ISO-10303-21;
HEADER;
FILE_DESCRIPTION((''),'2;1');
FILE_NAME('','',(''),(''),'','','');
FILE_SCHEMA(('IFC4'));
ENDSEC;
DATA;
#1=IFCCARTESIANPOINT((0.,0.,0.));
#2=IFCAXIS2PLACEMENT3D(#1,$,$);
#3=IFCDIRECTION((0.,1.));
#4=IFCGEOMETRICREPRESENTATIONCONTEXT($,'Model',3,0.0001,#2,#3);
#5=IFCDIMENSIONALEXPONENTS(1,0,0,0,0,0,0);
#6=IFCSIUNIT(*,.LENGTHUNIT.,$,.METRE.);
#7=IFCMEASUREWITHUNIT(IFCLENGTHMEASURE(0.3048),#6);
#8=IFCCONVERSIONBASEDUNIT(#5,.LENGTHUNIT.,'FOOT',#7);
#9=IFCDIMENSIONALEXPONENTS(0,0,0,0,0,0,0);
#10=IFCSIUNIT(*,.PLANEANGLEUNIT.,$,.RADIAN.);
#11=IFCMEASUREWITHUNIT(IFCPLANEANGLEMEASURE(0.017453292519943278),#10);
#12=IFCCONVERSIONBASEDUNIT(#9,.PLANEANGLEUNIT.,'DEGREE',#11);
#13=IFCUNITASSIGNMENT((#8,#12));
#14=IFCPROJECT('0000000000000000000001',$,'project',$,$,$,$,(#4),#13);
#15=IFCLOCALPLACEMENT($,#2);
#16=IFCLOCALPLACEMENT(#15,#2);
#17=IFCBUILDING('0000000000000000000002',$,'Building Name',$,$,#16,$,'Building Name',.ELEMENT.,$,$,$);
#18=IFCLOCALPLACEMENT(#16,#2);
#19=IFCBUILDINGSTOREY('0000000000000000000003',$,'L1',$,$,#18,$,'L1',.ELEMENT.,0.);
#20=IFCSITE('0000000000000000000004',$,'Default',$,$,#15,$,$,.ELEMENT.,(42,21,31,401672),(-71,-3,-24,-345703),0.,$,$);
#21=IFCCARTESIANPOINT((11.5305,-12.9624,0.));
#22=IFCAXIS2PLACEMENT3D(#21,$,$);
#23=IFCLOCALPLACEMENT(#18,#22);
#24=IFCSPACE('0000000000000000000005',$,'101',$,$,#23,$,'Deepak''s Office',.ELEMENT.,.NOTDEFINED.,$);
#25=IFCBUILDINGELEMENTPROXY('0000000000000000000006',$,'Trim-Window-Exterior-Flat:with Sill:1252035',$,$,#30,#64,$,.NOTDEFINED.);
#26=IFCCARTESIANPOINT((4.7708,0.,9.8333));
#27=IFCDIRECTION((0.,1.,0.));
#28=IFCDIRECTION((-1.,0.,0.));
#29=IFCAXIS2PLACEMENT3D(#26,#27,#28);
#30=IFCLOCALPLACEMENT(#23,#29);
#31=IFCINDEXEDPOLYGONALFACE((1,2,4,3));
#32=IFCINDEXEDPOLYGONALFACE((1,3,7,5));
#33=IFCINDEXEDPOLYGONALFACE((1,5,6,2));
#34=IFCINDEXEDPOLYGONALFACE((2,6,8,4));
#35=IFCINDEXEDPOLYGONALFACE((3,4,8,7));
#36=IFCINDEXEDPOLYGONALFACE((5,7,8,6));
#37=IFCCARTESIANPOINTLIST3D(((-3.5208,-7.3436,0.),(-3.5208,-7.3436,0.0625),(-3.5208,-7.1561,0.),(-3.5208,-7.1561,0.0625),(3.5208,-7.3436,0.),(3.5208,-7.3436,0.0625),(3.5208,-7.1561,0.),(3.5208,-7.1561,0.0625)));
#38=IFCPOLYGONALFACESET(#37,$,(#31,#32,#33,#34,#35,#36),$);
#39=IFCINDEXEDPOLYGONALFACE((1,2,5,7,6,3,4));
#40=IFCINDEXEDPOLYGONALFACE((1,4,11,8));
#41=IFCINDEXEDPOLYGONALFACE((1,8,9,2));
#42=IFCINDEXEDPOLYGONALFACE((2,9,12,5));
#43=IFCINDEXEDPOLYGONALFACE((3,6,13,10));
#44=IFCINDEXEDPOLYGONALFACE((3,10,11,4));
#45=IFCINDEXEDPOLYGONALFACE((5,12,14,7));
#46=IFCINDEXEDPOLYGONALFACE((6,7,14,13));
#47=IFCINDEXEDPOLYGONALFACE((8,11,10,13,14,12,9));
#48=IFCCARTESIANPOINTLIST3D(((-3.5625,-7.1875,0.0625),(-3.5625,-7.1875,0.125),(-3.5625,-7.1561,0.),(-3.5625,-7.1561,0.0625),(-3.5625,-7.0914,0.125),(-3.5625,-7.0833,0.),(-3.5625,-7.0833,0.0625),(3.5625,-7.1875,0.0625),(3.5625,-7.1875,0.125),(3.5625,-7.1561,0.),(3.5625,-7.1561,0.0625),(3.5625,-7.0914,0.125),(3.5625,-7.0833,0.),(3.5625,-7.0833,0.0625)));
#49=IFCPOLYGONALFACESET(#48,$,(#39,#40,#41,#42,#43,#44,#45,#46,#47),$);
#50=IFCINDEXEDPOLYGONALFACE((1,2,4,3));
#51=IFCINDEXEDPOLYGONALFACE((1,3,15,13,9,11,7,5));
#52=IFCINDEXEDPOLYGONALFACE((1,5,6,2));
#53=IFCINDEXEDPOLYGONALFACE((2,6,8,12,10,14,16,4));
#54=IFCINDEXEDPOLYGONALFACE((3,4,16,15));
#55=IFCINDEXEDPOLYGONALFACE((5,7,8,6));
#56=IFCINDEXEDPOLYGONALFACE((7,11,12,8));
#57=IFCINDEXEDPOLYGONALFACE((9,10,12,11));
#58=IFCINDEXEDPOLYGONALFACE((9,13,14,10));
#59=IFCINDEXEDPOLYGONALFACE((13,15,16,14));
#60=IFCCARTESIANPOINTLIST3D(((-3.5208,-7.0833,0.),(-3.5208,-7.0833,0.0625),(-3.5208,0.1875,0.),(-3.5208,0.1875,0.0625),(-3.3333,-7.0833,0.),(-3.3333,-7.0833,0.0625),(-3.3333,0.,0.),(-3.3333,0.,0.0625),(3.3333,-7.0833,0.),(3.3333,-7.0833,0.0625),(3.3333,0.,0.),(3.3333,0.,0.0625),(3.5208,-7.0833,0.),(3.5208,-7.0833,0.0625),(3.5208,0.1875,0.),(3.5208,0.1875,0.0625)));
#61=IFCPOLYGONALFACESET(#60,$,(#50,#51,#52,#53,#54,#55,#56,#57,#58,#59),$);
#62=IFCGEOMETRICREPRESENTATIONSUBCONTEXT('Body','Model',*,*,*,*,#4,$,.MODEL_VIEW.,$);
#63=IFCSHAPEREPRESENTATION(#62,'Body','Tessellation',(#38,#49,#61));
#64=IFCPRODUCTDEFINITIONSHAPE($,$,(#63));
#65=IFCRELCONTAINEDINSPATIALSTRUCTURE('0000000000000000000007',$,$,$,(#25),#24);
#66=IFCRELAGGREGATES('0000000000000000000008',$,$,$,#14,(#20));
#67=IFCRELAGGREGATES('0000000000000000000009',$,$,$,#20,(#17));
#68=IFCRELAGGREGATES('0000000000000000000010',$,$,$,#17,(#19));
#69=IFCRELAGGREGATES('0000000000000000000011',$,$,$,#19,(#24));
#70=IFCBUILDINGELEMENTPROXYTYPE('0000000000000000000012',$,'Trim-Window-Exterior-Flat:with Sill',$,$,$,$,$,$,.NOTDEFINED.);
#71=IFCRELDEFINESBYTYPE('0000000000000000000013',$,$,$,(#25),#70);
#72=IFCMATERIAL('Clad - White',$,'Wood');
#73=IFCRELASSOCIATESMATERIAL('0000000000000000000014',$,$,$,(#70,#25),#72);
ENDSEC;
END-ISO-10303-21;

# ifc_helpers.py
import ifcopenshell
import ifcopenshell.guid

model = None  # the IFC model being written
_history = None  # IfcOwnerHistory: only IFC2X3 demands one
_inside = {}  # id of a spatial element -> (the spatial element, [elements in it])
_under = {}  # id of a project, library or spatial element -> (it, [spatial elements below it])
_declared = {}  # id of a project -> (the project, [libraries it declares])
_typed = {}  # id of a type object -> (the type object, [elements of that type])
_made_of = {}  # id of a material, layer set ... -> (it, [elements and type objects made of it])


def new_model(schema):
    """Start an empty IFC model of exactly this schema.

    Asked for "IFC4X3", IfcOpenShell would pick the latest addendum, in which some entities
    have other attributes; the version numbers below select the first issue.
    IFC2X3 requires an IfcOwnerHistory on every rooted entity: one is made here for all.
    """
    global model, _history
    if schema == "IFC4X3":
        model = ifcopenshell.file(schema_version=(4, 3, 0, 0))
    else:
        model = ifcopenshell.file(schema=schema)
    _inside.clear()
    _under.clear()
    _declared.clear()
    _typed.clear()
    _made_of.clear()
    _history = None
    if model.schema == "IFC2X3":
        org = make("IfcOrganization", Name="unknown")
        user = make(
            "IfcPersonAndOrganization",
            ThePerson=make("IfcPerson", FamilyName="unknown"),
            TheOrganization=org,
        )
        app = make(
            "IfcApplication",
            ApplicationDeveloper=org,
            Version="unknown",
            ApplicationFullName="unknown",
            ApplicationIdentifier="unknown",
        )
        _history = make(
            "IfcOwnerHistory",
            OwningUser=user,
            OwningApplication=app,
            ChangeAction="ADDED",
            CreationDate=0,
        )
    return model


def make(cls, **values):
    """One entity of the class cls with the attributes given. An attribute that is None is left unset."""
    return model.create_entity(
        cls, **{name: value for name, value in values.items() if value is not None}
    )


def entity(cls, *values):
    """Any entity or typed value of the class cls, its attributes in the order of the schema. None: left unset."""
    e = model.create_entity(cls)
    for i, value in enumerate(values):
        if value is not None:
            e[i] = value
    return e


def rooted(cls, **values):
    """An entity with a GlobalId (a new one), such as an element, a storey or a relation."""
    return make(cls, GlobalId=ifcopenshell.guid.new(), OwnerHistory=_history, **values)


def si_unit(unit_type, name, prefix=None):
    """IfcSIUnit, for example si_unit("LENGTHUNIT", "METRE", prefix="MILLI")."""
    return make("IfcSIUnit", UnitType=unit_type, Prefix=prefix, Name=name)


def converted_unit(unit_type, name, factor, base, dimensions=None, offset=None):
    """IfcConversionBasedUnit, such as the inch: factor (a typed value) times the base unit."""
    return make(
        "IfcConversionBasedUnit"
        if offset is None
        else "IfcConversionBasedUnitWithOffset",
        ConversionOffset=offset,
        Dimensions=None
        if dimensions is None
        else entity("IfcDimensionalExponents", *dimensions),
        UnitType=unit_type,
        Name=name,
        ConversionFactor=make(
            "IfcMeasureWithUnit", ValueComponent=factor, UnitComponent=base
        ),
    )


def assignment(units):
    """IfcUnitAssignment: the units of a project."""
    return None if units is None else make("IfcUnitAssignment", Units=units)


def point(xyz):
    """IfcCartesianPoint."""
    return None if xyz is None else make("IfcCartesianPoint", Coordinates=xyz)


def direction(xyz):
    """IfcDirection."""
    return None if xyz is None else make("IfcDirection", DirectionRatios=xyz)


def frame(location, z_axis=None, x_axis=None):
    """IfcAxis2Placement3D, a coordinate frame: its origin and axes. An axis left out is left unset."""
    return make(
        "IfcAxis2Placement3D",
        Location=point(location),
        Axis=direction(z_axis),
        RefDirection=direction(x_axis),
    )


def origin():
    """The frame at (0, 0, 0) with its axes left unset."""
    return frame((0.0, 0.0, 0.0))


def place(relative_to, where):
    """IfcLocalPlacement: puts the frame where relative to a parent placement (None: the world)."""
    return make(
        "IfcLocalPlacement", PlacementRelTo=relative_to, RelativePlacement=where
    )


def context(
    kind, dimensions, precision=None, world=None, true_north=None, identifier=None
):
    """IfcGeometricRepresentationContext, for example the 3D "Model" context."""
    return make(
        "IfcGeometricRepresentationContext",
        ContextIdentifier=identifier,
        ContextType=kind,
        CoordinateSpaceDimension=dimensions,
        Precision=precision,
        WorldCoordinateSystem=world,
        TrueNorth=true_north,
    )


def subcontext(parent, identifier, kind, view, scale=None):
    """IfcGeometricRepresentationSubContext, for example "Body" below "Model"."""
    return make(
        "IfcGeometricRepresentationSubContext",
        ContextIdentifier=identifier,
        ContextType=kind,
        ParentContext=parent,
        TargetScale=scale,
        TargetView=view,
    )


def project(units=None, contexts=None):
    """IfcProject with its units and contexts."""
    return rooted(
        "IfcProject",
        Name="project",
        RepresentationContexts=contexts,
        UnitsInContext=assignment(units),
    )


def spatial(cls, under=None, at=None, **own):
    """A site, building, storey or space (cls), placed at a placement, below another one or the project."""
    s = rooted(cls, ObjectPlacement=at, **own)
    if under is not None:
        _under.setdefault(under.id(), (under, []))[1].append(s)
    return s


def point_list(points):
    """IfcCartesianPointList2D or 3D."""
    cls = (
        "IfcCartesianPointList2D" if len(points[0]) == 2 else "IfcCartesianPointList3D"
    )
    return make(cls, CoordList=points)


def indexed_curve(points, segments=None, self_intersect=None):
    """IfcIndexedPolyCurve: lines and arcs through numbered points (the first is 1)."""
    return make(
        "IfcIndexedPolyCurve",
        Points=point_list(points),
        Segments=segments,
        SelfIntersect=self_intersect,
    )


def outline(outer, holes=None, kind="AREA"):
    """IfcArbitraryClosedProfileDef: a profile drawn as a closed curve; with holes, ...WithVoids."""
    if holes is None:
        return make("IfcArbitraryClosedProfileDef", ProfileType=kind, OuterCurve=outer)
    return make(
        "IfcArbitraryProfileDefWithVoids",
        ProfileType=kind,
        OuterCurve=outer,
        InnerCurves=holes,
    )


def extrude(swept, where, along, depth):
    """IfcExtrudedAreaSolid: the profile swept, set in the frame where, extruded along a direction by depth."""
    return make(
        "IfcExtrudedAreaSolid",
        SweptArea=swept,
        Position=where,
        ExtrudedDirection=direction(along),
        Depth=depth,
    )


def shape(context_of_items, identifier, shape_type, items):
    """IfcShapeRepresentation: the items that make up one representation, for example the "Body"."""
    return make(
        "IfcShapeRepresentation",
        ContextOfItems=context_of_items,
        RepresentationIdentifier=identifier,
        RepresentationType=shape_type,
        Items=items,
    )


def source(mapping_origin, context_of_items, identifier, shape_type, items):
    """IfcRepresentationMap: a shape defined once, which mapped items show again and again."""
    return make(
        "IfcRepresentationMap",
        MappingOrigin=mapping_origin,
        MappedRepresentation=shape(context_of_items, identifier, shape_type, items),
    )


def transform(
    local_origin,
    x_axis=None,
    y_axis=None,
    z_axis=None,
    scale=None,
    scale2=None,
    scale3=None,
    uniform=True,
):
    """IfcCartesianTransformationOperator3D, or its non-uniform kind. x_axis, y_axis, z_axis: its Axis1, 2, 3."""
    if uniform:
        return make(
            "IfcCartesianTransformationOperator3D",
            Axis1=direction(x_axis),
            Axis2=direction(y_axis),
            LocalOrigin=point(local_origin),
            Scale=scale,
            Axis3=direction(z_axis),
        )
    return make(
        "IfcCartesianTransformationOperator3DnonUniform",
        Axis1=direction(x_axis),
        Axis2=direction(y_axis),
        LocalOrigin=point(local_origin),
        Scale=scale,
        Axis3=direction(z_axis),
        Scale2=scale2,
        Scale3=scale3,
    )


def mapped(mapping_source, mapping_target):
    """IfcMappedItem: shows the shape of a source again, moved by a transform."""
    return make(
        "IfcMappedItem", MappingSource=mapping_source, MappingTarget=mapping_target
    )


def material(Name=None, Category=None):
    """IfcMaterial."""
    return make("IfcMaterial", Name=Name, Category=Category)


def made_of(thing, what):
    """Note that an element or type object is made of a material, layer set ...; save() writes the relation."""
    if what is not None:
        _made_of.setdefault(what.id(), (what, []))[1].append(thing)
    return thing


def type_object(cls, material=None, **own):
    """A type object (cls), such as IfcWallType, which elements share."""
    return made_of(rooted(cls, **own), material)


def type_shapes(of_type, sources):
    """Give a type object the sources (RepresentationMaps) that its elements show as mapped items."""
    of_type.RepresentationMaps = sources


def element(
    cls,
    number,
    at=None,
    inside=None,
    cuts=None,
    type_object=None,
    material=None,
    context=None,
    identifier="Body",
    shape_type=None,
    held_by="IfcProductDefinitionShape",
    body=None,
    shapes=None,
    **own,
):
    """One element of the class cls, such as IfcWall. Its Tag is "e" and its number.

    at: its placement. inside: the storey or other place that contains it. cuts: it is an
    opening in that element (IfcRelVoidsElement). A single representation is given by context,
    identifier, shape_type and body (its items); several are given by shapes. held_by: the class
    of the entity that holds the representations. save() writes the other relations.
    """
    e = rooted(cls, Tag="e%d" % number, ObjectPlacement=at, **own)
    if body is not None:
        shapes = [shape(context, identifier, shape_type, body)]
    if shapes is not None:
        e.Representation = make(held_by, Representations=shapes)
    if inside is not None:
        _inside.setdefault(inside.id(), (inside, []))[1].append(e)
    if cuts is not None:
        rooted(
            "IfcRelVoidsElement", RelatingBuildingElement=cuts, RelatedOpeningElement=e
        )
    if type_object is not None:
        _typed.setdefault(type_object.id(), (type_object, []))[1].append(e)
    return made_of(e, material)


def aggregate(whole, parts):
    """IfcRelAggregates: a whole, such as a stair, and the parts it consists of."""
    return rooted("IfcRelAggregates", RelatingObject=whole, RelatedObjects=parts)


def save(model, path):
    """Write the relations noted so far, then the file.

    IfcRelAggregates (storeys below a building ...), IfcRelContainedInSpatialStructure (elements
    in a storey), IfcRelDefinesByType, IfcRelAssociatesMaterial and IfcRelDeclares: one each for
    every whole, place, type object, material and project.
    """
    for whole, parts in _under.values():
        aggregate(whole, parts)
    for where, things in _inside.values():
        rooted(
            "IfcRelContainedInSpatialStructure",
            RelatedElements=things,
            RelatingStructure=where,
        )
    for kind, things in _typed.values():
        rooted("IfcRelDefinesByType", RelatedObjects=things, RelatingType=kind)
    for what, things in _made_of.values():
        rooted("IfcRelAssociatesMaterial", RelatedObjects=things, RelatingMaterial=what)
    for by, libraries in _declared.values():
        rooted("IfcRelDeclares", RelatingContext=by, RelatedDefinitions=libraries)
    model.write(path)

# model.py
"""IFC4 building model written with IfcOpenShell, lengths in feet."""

from ifc_helpers import new_model, entity, si_unit, converted_unit, direction, frame, origin, place, context, subcontext, project, spatial, indexed_curve, outline, extrude, source, transform, mapped, material, type_object, type_shapes, element, save


model = new_model("IFC4")

# Units and contexts
model_context = context("Model", 3, precision=0.0001, world=origin(), true_north=direction((0.0, 1.0)))
body_context = subcontext(model_context, "Body", "Model", "MODEL_VIEW")
ifc_project = project(units=[converted_unit("LENGTHUNIT", "FOOT", entity("IfcLengthMeasure", 0.3048), si_unit("LENGTHUNIT", "METRE"), dimensions=[1, 0, 0, 0, 0, 0, 0]), converted_unit("PLANEANGLEUNIT", "DEGREE", entity("IfcPlaneAngleMeasure", 0.017453292519943278), si_unit("PLANEANGLEUNIT", "RADIAN"), dimensions=[0, 0, 0, 0, 0, 0, 0])], contexts=[model_context])

# Site, building, storey
site_placement = place(None, origin())
site = spatial("IfcSite", under=ifc_project, at=site_placement, Name="Default", CompositionType="ELEMENT", RefLatitude=(42, 21, 31, 401672), RefLongitude=(-71, -3, -24, -345703), RefElevation=0.0)
building_placement = place(site_placement, origin())
building = spatial("IfcBuilding", under=site, at=building_placement, Name="Building Name", LongName="Building Name", CompositionType="ELEMENT")
storey_placement = place(building_placement, origin())
storey = spatial("IfcBuildingStorey", under=building, at=storey_placement, Name="L1", LongName="L1", CompositionType="ELEMENT", Elevation=0.0)

# Shared definitions
ifc_material_1 = material(Name="Clad - White", Category="Wood")

# Shared definitions
space_1_placement = place(storey_placement, frame((11.5305, -12.9624, 0.0)))
space_1 = spatial("IfcSpace", under=storey, at=space_1_placement, Name="101", LongName="Deepak's Office", CompositionType="ELEMENT", PredefinedType="NOTDEFINED")

# Building element proxy
building_element_proxy_type_1 = type_object("IfcBuildingElementProxyType", Name="Trim-Window-Exterior-Flat:with Sill", PredefinedType="NOTDEFINED", material=ifc_material_1)
shared_shape_1 = source(origin(), body_context, "Body", "SweptSolid", [
    extrude(outline(indexed_curve([(-3.5208, -0.0938), (3.5208, -0.0938), (3.5208, 0.0938), (-3.5208, 0.0938), (-3.5208, -0.0938)], self_intersect=False)), frame((0.0, -7.2499, 0.0), z_axis=(0.0, 0.0, 1.0), x_axis=(-1.0, 0.0, 0.0)), (0.0, 0.0, 1.0), 0.0625),
    extrude(outline(indexed_curve([(-0.0625, -0.0525), (0.0, -0.0525), (0.0, -0.0211), (0.0625, -0.0211), (0.0625, 0.0517), (0.0, 0.0517), (-0.0625, 0.0436), (-0.0625, -0.0525)], self_intersect=False)), frame((-3.5625, -7.135, 0.0625), z_axis=(1.0, 0.0, 0.0), x_axis=(0.0, 0.0, -1.0)), (0.0, 0.0, 1.0), 7.125),
    extrude(outline(indexed_curve([(-3.6823, -3.5208), (3.5885, -3.5208), (3.5885, -3.3333), (-3.4948, -3.3333), (-3.4948, 3.3333), (3.5885, 3.3333), (3.5885, 3.5208), (-3.6823, 3.5208), (-3.6823, -3.5208)], self_intersect=False)), frame((0.0, -3.4948, 0.0), z_axis=(0.0, 0.0, 1.0), x_axis=(0.0, -1.0, 0.0)), (0.0, 0.0, 1.0), 0.0625),
])
type_shapes(building_element_proxy_type_1, [shared_shape_1])
proxy_1_placement = place(space_1_placement, frame((4.7708, 0.0, 9.8333), z_axis=(0.0, 1.0, 0.0), x_axis=(-1.0, 0.0, 0.0)))
element("IfcBuildingElementProxy", 1, at=proxy_1_placement, inside=space_1, type_object=building_element_proxy_type_1, material=ifc_material_1, Name="Trim-Window-Exterior-Flat:with Sill:1252035", PredefinedType="NOTDEFINED", context=body_context, shape_type="MappedRepresentation", body=[
    mapped(shared_shape_1, transform((0.0, 0.0, 0.0), scale=1.0)),
])

save(model, "model.ifc")
